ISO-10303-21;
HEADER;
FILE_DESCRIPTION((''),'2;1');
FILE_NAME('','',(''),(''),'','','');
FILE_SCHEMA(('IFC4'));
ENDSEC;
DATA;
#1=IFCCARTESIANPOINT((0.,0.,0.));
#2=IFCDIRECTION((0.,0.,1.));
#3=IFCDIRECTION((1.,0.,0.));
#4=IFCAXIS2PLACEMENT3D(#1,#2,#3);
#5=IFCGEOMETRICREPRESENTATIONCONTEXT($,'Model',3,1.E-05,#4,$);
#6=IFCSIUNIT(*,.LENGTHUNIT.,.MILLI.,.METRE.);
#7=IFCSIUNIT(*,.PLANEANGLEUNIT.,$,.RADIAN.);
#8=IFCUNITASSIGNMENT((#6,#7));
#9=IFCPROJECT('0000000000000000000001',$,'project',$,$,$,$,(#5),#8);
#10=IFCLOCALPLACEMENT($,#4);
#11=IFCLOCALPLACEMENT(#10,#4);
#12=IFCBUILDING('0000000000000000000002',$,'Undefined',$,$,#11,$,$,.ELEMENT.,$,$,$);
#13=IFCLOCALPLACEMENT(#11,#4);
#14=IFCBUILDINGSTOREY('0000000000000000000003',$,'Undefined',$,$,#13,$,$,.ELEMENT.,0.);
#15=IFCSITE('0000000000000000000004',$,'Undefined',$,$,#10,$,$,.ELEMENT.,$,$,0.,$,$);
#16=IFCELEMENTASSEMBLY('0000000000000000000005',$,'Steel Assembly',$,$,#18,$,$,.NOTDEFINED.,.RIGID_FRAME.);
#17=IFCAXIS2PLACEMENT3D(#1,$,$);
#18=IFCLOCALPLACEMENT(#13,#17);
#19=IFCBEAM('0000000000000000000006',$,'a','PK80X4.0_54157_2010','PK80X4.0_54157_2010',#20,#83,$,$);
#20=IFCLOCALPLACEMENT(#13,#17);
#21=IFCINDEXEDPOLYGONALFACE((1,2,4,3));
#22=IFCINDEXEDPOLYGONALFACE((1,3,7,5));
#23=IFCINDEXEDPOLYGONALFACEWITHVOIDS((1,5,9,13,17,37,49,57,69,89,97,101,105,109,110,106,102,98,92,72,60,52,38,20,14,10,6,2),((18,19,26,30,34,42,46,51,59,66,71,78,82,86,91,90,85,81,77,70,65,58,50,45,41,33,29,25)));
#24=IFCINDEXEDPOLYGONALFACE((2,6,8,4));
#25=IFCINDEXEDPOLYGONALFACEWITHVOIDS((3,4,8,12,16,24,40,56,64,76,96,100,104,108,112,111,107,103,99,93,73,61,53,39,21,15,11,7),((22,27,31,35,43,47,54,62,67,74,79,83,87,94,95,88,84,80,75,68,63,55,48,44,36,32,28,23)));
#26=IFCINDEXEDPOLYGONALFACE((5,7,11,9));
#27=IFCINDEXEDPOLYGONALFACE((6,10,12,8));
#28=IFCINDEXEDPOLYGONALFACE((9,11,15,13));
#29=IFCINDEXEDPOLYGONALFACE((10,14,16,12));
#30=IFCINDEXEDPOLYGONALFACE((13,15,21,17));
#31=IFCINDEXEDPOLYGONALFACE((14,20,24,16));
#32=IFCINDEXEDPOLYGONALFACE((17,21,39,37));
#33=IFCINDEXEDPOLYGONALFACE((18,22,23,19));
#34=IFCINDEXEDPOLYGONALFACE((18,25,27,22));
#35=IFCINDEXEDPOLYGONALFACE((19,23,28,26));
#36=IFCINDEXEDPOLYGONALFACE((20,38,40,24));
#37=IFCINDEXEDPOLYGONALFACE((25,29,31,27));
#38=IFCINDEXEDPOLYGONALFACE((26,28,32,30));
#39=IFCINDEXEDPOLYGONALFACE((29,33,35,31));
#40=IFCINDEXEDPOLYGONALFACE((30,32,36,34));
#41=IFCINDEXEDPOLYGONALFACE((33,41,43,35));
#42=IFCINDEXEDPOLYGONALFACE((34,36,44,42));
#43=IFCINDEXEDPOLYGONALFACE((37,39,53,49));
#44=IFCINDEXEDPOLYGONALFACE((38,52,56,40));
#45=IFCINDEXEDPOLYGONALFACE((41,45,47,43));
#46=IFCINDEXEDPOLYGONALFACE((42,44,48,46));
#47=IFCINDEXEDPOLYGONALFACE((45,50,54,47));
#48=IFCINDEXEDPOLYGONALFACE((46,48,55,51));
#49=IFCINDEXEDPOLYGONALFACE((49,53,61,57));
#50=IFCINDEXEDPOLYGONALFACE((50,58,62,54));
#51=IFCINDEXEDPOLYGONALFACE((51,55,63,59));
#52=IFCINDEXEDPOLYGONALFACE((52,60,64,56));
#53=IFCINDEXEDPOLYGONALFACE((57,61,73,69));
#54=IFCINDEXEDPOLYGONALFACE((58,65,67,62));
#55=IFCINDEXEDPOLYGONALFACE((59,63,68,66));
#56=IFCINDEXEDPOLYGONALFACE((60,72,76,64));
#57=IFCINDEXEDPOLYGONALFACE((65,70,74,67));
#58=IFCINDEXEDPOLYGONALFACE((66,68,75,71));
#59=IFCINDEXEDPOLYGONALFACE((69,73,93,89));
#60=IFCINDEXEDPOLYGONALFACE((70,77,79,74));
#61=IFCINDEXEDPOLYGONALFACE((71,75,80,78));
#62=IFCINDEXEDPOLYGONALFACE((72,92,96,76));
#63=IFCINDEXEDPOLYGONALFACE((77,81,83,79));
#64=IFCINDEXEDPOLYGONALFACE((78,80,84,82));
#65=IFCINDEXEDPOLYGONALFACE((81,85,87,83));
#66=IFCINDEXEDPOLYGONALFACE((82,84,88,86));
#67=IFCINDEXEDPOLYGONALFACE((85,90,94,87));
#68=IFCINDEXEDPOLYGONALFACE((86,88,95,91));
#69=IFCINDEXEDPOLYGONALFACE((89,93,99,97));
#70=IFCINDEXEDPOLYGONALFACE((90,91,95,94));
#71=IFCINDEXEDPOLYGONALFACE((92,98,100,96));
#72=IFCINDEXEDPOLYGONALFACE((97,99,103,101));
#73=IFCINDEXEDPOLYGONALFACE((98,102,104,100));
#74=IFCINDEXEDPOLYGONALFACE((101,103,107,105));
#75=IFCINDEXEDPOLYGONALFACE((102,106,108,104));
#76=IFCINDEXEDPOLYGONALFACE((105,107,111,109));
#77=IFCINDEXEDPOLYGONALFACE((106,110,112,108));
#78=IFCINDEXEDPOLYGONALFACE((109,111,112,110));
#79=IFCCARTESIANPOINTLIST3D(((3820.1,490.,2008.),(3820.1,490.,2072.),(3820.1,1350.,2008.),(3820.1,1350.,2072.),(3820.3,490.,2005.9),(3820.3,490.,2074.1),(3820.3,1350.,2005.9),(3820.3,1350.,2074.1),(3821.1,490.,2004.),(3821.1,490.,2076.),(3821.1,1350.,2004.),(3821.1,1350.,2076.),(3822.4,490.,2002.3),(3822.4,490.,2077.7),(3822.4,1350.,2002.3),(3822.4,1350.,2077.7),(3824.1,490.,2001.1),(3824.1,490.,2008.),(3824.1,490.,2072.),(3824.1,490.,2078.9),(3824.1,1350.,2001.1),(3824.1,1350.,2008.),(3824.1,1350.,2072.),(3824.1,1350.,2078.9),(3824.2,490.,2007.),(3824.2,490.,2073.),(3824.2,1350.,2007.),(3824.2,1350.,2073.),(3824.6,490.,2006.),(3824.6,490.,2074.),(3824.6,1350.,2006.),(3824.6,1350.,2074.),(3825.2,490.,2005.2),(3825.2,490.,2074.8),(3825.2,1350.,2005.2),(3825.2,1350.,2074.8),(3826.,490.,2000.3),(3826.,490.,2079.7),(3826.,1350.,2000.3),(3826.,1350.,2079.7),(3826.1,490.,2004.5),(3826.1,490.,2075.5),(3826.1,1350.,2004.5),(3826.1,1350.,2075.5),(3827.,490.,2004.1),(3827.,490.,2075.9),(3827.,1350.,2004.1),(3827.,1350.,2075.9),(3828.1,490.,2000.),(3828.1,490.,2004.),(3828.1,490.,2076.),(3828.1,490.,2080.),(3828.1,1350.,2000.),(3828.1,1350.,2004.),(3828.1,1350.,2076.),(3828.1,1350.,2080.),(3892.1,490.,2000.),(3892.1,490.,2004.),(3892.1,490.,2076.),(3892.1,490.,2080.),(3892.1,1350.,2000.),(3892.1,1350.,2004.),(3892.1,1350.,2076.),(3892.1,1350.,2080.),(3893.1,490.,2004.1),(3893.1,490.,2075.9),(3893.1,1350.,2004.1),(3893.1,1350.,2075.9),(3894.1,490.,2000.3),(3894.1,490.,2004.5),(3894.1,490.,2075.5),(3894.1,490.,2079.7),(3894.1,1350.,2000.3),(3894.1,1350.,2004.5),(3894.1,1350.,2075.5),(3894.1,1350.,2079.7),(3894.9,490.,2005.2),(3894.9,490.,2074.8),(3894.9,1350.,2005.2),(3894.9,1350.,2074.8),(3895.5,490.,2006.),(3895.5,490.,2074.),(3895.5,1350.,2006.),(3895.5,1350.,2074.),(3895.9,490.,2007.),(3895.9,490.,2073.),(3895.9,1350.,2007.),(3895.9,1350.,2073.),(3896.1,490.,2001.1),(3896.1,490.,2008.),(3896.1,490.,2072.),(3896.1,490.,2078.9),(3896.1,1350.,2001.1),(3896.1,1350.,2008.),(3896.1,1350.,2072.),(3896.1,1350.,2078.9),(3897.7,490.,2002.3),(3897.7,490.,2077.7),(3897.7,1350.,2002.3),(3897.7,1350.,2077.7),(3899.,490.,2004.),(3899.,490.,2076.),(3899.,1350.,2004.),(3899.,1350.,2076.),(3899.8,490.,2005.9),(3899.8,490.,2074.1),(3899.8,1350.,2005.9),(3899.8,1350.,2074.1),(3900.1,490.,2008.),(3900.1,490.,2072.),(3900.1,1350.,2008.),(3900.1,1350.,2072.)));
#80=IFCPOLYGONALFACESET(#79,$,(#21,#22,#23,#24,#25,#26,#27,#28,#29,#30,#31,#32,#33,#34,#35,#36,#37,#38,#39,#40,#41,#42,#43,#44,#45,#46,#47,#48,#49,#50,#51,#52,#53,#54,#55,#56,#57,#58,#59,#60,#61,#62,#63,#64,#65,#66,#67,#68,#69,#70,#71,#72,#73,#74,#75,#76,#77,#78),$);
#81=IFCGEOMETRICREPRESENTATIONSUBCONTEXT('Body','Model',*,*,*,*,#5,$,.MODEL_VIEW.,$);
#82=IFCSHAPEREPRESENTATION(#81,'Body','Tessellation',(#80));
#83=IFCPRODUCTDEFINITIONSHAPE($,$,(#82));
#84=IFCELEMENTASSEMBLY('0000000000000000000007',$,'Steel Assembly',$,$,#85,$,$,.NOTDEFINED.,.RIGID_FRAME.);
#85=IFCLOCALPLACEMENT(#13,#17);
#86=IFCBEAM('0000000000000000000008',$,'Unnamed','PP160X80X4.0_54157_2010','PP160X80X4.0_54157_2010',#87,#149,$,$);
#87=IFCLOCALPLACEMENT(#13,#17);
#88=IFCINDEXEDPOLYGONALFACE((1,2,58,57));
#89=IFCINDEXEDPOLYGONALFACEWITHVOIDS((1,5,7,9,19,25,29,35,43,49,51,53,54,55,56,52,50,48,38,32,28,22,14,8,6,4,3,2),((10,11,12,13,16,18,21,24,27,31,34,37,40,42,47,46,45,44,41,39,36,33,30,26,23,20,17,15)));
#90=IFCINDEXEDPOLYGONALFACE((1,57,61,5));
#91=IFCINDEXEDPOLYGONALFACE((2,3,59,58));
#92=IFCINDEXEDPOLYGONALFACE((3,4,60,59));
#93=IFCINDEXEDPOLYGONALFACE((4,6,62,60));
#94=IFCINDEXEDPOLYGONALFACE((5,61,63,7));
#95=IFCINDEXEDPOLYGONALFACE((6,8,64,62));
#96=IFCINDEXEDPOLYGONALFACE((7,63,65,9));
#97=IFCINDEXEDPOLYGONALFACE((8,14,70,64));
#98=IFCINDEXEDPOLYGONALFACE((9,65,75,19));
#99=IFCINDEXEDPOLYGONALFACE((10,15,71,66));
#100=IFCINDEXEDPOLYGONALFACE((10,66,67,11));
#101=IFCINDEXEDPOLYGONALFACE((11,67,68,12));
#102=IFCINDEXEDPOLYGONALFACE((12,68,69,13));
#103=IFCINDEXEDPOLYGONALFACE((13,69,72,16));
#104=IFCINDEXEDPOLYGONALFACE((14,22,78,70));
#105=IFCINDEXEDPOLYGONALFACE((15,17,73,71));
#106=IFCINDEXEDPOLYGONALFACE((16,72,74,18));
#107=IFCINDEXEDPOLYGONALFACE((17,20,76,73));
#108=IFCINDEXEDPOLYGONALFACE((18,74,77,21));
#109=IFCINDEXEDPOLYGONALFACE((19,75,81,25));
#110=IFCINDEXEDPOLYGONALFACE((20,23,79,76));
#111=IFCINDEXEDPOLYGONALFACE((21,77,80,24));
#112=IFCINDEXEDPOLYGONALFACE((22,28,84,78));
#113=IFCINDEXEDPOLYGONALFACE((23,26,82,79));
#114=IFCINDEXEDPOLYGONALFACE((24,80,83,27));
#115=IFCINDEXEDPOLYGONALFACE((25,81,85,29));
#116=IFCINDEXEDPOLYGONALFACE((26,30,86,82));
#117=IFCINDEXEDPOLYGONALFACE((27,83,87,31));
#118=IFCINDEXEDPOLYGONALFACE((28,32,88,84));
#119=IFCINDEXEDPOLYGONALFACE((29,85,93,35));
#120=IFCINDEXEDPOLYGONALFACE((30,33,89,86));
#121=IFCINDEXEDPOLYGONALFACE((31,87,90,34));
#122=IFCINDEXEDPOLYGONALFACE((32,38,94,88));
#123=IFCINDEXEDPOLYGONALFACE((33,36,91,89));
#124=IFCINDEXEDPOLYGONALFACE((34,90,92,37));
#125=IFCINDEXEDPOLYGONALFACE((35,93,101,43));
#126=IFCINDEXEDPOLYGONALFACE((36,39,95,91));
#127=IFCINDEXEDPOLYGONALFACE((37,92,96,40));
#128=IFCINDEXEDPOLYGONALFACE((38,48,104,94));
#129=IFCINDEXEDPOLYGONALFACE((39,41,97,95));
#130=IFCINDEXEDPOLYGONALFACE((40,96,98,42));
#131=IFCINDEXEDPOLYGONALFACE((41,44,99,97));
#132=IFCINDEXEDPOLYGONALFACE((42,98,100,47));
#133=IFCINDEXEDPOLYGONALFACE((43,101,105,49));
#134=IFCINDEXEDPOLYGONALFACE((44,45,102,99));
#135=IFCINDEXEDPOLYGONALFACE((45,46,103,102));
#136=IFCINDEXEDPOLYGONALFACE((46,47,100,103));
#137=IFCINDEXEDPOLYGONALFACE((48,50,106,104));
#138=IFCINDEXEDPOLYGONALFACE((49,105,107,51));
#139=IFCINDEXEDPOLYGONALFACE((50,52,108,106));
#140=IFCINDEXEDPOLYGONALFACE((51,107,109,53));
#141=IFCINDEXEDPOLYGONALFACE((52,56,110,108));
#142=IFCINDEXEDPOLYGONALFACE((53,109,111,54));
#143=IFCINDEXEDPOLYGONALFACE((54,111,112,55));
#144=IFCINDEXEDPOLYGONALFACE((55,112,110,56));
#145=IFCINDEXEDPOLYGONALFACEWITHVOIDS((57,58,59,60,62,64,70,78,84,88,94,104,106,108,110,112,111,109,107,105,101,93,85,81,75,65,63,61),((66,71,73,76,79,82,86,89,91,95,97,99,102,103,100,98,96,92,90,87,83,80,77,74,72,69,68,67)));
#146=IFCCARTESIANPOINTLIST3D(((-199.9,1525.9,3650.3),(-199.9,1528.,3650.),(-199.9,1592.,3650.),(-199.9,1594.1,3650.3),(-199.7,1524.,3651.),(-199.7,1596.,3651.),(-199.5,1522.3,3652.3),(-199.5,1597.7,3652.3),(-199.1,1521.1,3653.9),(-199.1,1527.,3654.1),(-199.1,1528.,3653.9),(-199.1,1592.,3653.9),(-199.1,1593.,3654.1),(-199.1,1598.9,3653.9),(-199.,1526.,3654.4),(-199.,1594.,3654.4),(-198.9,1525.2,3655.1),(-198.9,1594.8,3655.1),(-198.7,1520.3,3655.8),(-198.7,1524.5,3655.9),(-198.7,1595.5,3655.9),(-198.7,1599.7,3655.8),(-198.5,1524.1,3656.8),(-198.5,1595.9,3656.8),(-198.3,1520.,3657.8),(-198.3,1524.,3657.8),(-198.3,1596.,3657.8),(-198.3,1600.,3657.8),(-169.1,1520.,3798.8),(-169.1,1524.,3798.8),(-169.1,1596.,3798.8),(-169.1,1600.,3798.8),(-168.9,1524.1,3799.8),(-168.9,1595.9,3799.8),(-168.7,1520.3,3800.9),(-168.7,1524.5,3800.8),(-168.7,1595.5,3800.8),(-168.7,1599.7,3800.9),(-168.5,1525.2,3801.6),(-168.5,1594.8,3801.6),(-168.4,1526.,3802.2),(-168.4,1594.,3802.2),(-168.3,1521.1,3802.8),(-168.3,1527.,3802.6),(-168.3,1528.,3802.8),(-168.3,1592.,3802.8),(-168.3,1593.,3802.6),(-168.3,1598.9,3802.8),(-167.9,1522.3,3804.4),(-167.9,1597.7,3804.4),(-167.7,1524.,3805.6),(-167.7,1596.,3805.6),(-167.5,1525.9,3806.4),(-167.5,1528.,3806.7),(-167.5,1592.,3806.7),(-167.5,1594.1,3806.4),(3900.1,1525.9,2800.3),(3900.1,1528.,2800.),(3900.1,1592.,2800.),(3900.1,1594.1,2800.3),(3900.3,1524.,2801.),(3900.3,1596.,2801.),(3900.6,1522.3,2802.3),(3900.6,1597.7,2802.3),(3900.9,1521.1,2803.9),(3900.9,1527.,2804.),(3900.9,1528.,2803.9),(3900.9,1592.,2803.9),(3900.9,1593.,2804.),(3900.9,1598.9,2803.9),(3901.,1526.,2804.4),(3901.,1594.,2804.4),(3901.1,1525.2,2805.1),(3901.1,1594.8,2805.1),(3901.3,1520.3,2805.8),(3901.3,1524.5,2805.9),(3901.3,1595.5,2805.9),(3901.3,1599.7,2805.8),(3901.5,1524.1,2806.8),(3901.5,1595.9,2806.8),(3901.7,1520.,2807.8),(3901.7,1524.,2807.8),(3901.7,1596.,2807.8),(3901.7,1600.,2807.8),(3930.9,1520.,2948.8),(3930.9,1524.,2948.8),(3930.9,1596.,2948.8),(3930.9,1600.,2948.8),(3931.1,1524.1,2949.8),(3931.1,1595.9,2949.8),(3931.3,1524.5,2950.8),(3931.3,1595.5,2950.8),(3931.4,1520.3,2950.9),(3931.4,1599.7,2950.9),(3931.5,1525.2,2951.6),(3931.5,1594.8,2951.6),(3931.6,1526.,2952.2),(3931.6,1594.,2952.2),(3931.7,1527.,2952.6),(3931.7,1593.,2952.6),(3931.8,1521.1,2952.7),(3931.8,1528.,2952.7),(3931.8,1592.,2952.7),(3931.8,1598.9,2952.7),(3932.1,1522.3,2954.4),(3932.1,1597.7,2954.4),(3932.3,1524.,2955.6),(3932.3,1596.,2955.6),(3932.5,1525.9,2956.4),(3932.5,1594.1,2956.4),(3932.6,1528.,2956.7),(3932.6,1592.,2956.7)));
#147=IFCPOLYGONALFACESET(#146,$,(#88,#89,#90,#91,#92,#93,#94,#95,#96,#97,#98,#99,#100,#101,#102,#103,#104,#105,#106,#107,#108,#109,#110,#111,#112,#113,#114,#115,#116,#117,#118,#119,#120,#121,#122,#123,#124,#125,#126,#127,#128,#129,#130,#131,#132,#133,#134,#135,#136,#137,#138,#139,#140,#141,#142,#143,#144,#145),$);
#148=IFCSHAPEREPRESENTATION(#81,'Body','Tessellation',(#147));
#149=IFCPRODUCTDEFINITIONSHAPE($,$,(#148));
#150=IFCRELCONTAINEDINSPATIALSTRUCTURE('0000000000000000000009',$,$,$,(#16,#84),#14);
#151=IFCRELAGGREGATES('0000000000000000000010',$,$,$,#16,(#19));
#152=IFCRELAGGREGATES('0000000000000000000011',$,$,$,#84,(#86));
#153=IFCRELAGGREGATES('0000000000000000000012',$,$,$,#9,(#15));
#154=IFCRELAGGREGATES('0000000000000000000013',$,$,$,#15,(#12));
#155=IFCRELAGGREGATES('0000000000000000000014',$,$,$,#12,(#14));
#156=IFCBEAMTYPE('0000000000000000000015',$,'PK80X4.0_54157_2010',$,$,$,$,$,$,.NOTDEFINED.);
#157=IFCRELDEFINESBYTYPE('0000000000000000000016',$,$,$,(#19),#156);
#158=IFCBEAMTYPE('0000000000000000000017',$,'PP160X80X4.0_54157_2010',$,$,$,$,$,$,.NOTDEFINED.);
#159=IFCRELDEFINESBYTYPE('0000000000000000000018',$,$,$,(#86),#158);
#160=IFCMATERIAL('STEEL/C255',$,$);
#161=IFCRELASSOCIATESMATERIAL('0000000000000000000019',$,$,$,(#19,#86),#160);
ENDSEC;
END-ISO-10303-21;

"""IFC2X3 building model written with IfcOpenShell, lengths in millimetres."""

from ifc_helpers import new_model, si_unit, frame, origin_with_axes, origin_2d_with_axis, place, context, subcontext, project, spatial, hollow_rectangle, extrude, material, type_object, element, aggregate, save


model = new_model("IFC2X3")

# Units and contexts
model_context = context("Model", 3, precision=1e-05, world=origin_with_axes())
body_context = subcontext(model_context, "Body", "Model", "MODEL_VIEW")
ifc_project = project(units=[si_unit("LENGTHUNIT", "METRE", prefix="MILLI"), si_unit("PLANEANGLEUNIT", "RADIAN")], contexts=[model_context])

# Site, building, storey
site_placement = place(None, origin_with_axes())
site = spatial("IfcSite", under=ifc_project, at=site_placement, Name="Undefined", CompositionType="ELEMENT", RefElevation=0.0)
building_placement = place(site_placement, origin_with_axes())
building = spatial("IfcBuilding", under=site, at=building_placement, Name="Undefined", CompositionType="ELEMENT")
storey_placement = place(building_placement, origin_with_axes())
storey = spatial("IfcBuildingStorey", under=building, at=storey_placement, Name="Undefined", CompositionType="ELEMENT", Elevation=0.0)

# Element assemblies, beams
ifc_material_1 = material(Name="STEEL/C255")
beam_type_1 = type_object("IfcBeamType", Name="PK80X4.0_54157_2010", PredefinedType="NOTDEFINED")
assembly_1_placement = place(storey_placement, origin_with_axes())
assembly_1 = element("IfcElementAssembly", 1, at=assembly_1_placement, inside=storey, Name="Steel Assembly", AssemblyPlace="NOTDEFINED", PredefinedType="RIGID_FRAME")
beam_1_placement = place(assembly_1_placement, frame((3860.1, 490.0, 2040.0), z_axis=(0.0, 0.0, 1.0), x_axis=(0.0, 1.0, 0.0)))
beam_1 = element("IfcBeam", 2, at=beam_1_placement, type_object=beam_type_1, material=ifc_material_1, Name="a", Description="PK80X4.0_54157_2010", ObjectType="PK80X4.0_54157_2010", context=body_context, shape_type="SweptSolid", body=[
    extrude(hollow_rectangle(XDim=80.0, YDim=80.0, WallThickness=4.0, InnerFilletRadius=4.0, OuterFilletRadius=8.0, at=origin_2d_with_axis()), frame((860.0, 0.0, 0.0), z_axis=(-1.0, 0.0, 0.0), x_axis=(0.0, -1.0, 0.0)), (0.0, 0.0, 1.0), 860.0),
])
aggregate(assembly_1, [beam_1])
assembly_2_placement = place(storey_placement, origin_with_axes())
assembly_2 = element("IfcElementAssembly", 3, at=assembly_2_placement, inside=storey, Name="Steel Assembly", AssemblyPlace="NOTDEFINED", PredefinedType="RIGID_FRAME")
beam_type_2 = type_object("IfcBeamType", Name="PP160X80X4.0_54157_2010", PredefinedType="NOTDEFINED")
beam_2_placement = place(assembly_2_placement, frame((3916.3, 1560.0, 2878.3), z_axis=(0.203, 0.0, 0.979179), x_axis=(-0.979179, 0.0, 0.203)))
beam_2 = element("IfcBeam", 4, at=beam_2_placement, type_object=beam_type_2, material=ifc_material_1, Name="Unnamed", Description="PP160X80X4.0_54157_2010", ObjectType="PP160X80X4.0_54157_2010", context=body_context, shape_type="SweptSolid", body=[
    extrude(hollow_rectangle(XDim=80.0, YDim=160.0, WallThickness=4.0, InnerFilletRadius=4.0, OuterFilletRadius=8.0, at=origin_2d_with_axis()), frame((4187.2, 0.0, 0.0), z_axis=(-1.0, 0.0, 0.0), x_axis=(0.0, -1.0, 0.0)), (0.0, 0.0, 1.0), 4187.2),
])
aggregate(assembly_2, [beam_2])

save(model, "model.ifc")
